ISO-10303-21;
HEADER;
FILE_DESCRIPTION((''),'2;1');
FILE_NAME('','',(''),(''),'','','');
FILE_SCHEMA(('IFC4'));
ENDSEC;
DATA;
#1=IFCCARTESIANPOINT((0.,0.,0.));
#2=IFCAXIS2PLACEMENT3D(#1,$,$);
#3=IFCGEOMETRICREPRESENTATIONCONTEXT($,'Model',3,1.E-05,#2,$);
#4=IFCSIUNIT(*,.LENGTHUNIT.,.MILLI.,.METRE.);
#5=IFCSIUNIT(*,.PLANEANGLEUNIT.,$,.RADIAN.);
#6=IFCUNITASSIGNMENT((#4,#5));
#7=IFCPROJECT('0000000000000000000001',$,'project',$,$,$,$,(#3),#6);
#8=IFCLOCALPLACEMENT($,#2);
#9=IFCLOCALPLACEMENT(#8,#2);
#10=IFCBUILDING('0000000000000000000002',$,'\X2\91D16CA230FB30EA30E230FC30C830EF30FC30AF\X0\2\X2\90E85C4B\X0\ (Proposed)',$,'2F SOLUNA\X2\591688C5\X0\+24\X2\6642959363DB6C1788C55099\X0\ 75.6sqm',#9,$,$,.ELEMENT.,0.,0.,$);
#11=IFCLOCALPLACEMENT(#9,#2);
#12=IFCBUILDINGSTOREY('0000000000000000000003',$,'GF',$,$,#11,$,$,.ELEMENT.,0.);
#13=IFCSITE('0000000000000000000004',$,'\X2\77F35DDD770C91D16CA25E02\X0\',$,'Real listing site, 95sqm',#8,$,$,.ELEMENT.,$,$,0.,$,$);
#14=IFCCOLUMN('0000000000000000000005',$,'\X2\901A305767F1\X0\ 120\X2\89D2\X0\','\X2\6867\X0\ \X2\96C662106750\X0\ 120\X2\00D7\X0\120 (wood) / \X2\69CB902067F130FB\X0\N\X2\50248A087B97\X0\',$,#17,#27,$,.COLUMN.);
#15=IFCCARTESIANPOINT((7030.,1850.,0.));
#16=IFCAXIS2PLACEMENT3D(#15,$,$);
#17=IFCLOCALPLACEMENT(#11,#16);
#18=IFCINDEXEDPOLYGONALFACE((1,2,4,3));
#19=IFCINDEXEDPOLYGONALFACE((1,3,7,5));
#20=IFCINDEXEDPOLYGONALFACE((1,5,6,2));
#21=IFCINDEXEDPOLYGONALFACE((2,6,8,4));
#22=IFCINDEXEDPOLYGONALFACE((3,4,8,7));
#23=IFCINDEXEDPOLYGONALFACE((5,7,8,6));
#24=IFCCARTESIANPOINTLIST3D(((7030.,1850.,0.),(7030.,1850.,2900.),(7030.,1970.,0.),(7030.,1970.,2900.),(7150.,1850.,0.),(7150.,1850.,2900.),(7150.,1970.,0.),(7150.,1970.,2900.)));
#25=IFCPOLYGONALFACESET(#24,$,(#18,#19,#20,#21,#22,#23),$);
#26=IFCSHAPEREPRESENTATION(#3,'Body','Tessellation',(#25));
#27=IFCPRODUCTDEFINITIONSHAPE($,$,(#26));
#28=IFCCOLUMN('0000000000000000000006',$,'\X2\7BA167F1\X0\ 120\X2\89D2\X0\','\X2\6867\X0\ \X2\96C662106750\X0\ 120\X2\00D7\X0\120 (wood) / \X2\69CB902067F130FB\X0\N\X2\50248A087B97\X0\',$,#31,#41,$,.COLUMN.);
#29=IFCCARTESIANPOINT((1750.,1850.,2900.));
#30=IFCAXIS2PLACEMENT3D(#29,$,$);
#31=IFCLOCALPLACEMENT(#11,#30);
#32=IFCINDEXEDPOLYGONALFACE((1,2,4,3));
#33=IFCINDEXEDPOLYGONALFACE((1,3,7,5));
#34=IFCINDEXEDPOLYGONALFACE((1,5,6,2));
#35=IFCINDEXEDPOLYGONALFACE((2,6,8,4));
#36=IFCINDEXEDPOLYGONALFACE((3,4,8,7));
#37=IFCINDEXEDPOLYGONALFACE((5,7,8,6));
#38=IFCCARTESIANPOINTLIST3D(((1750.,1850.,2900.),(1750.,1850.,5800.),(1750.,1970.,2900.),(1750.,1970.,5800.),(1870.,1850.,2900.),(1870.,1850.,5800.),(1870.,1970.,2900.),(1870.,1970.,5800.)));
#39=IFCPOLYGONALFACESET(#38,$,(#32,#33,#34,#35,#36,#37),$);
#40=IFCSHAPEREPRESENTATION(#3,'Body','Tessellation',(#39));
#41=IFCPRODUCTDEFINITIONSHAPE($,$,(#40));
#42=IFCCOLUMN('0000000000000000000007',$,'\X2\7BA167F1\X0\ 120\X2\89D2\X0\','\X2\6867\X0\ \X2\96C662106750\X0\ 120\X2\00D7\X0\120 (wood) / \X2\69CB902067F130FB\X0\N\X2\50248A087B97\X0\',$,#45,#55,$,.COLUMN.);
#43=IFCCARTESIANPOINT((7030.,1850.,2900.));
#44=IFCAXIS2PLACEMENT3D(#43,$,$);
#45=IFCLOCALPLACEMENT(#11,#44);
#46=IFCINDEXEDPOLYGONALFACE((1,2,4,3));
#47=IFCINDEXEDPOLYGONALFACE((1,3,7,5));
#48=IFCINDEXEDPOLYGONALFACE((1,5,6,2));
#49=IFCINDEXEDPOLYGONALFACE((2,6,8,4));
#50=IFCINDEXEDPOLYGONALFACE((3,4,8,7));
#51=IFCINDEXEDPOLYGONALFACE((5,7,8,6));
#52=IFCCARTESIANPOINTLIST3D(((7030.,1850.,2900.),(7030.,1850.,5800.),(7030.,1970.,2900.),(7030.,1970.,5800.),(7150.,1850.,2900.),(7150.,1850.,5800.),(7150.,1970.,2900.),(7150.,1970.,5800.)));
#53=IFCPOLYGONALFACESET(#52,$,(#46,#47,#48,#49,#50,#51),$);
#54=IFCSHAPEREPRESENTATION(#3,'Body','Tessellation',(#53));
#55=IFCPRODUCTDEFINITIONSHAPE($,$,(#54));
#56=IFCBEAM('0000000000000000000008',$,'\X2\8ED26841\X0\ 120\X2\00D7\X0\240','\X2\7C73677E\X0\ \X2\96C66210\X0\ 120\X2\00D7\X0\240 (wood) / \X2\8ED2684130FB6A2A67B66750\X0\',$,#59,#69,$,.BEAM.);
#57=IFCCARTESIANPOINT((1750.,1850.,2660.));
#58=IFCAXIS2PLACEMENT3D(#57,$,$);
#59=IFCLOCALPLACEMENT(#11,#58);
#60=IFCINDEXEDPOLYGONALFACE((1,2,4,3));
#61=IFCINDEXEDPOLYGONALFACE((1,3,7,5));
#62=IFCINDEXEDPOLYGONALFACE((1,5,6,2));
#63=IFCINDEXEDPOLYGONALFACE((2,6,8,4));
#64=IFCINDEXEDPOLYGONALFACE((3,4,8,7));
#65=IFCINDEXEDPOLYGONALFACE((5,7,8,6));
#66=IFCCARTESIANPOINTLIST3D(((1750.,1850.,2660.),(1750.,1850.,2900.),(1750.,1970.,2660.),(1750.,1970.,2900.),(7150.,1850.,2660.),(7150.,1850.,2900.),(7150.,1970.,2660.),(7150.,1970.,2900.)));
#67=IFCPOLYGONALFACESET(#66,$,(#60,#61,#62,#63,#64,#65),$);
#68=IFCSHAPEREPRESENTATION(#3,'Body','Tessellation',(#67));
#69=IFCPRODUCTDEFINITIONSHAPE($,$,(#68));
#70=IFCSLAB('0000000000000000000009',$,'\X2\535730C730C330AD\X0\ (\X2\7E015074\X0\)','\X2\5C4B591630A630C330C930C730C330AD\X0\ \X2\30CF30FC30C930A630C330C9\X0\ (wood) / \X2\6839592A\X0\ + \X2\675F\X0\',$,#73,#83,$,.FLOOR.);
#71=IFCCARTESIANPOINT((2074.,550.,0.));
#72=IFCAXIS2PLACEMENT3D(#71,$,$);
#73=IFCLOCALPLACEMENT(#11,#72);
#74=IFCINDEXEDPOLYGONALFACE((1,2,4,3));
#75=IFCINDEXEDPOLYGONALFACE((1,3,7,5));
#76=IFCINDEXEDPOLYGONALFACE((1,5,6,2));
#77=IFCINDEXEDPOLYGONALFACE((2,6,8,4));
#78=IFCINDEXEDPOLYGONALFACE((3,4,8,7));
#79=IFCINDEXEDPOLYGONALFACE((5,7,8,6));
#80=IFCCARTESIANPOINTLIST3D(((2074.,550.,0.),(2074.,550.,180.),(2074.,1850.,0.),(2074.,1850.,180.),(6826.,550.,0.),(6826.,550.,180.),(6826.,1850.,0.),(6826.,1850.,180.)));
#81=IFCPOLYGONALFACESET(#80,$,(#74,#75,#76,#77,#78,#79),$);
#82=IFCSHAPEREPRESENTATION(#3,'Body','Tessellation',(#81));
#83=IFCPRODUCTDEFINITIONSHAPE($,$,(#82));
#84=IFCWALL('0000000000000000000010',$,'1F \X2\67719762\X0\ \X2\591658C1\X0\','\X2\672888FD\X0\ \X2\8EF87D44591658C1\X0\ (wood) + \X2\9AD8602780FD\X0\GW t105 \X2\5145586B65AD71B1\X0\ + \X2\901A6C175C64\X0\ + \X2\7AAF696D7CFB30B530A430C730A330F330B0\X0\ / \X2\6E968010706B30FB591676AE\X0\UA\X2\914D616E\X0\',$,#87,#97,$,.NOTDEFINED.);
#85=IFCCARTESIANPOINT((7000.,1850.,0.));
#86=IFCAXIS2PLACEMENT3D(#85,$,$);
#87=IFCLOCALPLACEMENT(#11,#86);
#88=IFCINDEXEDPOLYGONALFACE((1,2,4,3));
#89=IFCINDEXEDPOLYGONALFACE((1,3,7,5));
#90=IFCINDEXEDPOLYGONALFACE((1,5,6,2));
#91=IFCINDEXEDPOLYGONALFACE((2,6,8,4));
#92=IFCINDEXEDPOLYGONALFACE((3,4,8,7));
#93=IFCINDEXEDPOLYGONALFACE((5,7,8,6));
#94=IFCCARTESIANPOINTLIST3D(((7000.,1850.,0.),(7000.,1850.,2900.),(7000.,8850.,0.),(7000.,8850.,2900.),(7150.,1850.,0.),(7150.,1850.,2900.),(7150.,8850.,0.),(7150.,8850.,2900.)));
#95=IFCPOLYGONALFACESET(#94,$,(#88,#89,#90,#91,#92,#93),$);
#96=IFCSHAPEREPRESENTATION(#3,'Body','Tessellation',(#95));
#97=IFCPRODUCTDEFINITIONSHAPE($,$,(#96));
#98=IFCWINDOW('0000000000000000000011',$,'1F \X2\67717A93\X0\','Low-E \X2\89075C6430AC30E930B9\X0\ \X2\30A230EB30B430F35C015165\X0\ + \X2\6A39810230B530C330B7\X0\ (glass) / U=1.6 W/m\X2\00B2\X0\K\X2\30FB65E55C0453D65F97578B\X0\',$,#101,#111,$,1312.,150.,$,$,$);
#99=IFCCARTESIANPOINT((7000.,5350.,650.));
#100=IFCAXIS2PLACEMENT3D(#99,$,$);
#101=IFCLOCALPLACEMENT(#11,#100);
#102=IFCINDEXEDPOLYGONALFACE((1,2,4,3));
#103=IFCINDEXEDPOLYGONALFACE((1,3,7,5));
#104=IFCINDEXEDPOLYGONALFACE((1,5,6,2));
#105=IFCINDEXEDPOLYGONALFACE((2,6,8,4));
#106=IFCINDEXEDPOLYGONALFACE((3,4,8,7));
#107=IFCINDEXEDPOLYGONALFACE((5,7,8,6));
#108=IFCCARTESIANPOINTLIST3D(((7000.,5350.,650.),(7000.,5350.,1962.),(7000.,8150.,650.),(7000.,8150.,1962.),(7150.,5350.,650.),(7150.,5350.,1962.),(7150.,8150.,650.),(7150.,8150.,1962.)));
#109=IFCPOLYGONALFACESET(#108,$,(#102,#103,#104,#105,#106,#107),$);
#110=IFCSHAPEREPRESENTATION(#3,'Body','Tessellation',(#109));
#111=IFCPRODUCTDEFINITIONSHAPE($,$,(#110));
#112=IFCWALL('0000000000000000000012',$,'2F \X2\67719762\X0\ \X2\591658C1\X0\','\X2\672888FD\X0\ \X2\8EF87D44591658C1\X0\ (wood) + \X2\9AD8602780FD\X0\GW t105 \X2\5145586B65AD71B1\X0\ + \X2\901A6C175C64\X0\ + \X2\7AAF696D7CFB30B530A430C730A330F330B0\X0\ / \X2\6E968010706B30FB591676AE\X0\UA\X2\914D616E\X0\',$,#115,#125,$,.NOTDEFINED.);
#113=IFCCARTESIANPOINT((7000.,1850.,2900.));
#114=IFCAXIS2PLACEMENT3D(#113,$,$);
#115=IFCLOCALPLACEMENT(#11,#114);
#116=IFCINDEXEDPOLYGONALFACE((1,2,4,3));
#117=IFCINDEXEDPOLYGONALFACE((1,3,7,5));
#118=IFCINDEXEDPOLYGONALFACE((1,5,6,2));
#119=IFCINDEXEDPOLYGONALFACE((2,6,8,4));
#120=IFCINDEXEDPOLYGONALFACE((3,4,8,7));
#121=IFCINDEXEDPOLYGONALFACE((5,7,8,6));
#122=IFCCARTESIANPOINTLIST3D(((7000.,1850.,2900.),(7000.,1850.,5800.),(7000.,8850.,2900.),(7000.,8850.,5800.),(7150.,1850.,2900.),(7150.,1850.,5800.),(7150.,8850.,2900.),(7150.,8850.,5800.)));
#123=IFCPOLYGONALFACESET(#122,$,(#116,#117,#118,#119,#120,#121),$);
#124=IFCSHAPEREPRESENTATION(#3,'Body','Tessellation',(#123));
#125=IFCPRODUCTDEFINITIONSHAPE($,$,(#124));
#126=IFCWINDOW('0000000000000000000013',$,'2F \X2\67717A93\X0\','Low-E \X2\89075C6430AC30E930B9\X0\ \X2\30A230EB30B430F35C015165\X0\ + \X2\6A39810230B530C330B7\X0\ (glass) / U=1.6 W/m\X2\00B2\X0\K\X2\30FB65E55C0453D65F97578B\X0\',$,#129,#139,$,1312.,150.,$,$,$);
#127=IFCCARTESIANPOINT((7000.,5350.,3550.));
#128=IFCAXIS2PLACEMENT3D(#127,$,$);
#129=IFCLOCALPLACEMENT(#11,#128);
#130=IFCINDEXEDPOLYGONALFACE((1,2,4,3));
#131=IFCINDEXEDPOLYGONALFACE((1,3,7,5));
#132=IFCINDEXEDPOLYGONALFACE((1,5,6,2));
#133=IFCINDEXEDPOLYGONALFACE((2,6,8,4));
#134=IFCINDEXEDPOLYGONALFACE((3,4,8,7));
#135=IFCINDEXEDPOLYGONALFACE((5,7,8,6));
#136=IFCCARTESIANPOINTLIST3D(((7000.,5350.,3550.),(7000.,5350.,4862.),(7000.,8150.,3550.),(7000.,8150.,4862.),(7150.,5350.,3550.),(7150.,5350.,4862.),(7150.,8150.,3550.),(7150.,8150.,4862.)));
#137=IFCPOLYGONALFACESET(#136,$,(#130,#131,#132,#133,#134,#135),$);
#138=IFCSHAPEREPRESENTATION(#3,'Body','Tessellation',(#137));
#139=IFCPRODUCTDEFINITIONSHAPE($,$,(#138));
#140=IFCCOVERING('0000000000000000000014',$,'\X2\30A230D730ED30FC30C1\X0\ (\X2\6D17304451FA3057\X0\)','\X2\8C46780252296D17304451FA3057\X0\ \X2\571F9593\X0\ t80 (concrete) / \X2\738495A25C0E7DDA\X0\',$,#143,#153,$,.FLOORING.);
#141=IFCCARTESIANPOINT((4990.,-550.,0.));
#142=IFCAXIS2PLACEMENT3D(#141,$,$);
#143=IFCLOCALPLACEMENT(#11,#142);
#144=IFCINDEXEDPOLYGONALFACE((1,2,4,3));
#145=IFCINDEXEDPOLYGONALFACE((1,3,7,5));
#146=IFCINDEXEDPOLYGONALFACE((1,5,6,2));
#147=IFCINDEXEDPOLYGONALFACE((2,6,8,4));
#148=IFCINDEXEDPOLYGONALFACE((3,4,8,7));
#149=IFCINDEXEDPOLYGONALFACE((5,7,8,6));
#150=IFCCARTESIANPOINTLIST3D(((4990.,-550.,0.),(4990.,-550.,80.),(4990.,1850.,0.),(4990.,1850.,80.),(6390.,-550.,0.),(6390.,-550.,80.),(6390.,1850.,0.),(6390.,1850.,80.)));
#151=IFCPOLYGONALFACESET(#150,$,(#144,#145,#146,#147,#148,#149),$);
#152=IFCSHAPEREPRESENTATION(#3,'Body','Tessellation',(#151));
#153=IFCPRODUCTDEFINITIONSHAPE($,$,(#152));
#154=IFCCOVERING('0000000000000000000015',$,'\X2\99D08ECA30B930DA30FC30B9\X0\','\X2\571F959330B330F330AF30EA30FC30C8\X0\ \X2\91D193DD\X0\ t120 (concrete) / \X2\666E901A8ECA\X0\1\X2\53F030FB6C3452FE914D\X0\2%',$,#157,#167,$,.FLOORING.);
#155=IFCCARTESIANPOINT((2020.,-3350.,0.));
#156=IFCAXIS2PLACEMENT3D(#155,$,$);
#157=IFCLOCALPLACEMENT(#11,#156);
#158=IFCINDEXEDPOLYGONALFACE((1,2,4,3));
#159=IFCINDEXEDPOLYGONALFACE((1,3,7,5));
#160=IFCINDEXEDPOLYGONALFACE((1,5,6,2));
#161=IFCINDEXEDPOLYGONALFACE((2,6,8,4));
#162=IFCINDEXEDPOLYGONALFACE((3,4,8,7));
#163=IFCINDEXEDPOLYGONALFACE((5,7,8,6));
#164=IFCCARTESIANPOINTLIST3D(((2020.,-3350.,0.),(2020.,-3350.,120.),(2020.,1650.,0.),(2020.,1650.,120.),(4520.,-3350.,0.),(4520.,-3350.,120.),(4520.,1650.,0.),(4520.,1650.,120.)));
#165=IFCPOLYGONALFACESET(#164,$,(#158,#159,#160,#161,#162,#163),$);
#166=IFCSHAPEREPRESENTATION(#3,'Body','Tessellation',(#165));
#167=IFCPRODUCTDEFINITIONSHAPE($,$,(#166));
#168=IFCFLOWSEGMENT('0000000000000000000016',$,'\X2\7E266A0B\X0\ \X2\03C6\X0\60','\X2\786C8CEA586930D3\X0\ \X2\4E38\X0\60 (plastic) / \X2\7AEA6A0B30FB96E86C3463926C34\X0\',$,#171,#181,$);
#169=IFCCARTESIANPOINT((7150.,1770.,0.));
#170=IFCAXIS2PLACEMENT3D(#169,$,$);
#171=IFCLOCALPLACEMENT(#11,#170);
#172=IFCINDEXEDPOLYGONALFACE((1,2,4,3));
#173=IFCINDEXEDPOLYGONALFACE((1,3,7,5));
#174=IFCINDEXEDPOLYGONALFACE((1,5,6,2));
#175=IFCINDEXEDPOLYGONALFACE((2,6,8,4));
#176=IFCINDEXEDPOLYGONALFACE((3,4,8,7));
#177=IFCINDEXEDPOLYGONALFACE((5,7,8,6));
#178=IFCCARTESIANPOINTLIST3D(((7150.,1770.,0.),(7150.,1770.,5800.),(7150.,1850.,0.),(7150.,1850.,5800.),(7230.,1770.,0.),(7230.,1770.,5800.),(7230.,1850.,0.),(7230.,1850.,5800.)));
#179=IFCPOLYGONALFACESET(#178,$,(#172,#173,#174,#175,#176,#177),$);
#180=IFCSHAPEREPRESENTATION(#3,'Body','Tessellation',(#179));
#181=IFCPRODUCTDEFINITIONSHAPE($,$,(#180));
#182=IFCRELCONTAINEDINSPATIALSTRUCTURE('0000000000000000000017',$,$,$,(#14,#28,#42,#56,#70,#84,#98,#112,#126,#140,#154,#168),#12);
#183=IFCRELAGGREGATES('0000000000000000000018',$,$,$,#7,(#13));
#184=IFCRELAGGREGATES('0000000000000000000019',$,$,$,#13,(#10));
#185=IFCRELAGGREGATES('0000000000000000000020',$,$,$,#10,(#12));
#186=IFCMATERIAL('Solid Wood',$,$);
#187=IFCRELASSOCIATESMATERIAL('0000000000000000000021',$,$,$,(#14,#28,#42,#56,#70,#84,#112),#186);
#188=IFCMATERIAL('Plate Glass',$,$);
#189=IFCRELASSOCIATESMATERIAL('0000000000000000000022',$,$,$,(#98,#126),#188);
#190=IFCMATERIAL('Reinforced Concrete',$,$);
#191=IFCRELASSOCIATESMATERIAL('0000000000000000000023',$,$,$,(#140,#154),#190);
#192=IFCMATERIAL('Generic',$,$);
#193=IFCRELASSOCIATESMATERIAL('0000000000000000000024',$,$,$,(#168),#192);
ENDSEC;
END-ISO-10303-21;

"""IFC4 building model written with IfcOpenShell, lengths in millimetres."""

from ifc_helpers import new_model, si_unit, frame, frame_2d, origin, place, context, project, spatial, rectangle, extrude, material, element, fill, save


model = new_model("IFC4")

# Units and contexts
model_context = context("Model", 3, precision=1e-05, world=origin())
ifc_project = project(units=[si_unit("LENGTHUNIT", "METRE", prefix="MILLI"), si_unit("PLANEANGLEUNIT", "RADIAN")], contexts=[model_context])

# Site, building, storey
site_placement = place(None, origin())
site = spatial("IfcSite", under=ifc_project, at=site_placement, Name="石川県金沢市", ObjectType="Real listing site, 95sqm", CompositionType="ELEMENT", RefElevation=0.0)
building_placement = place(site_placement, origin())
building = spatial("IfcBuilding", under=site, at=building_placement, Name="金沢・リモートワーク2部屋 (Proposed)", ObjectType="2F SOLUNA外装+24時間換気装備 75.6sqm", CompositionType="ELEMENT", ElevationOfRefHeight=0.0, ElevationOfTerrain=0.0)
storey_placement = place(building_placement, origin())
storey = spatial("IfcBuildingStorey", under=building, at=storey_placement, Name="GF", CompositionType="ELEMENT", Elevation=0.0)

# Columns
ifc_material_1 = material(Name="Solid Wood")
column_1_placement = place(storey_placement, frame((7030.0, 1850.0, 0.0)))
element("IfcColumn", 1, at=column_1_placement, inside=storey, material=ifc_material_1, Name="通し柱 120角", Description="桧 集成材 120×120 (wood) / 構造柱・N値計算", PredefinedType="COLUMN", context=model_context, shape_type="SweptSolid", body=[
    extrude(rectangle(XDim=120.0, YDim=120.0, at=frame_2d((60.0, 60.0))), frame((7030.0, 1850.0, 0.0)), (0.0, 0.0, 1.0), 2900.0),
])
column_2_placement = place(storey_placement, frame((1750.0, 1850.0, 2900.0)))
element("IfcColumn", 2, at=column_2_placement, inside=storey, material=ifc_material_1, Name="管柱 120角", Description="桧 集成材 120×120 (wood) / 構造柱・N値計算", PredefinedType="COLUMN", context=model_context, shape_type="SweptSolid", body=[
    extrude(rectangle(XDim=120.0, YDim=120.0, at=frame_2d((60.0, 60.0))), frame((1750.0, 1850.0, 2900.0)), (0.0, 0.0, 1.0), 2900.0),
])
column_3_placement = place(storey_placement, frame((7030.0, 1850.0, 2900.0)))
element("IfcColumn", 3, at=column_3_placement, inside=storey, material=ifc_material_1, Name="管柱 120角", Description="桧 集成材 120×120 (wood) / 構造柱・N値計算", PredefinedType="COLUMN", context=model_context, shape_type="SweptSolid", body=[
    extrude(rectangle(XDim=120.0, YDim=120.0, at=frame_2d((60.0, 60.0))), frame((7030.0, 1850.0, 2900.0)), (0.0, 0.0, 1.0), 2900.0),
])

# Beam
beam_1_placement = place(storey_placement, frame((1750.0, 1850.0, 2660.0)))
element("IfcBeam", 4, at=beam_1_placement, inside=storey, material=ifc_material_1, Name="軒桁 120×240", Description="米松 集成 120×240 (wood) / 軒桁・横架材", PredefinedType="BEAM", context=model_context, shape_type="SweptSolid", body=[
    extrude(rectangle(XDim=5400.0, YDim=120.0, at=frame_2d((2700.0, 60.0))), frame((1750.0, 1850.0, 2660.0)), (0.0, 0.0, 1.0), 240.0),
])

# Slab
slab_placement = place(storey_placement, frame((2074.0, 550.0, 0.0)))
element("IfcSlab", 5, at=slab_placement, inside=storey, material=ifc_material_1, Name="南デッキ (縁側)", Description="屋外ウッドデッキ ハードウッド (wood) / 根太 + 束", PredefinedType="FLOOR", context=model_context, shape_type="SweptSolid", body=[
    extrude(rectangle(XDim=4752.0, YDim=1300.0, at=frame_2d((2376.0, 650.0))), frame((2074.0, 550.0, 0.0)), (0.0, 0.0, 1.0), 180.0),
])

# Walls, openings, windows
wall_1_placement = place(storey_placement, frame((7000.0, 1850.0, 0.0)))
wall_1 = element("IfcWall", 6, at=wall_1_placement, inside=storey, material=ifc_material_1, Name="1F 東面 外壁", Description="木製 軸組外壁 (wood) + 高性能GW t105 充填断熱 + 通気層 + 窯業系サイディング / 準耐火・外皮UA配慮", PredefinedType="NOTDEFINED", context=model_context, shape_type="SweptSolid", body=[
    extrude(rectangle(XDim=150.0, YDim=7000.0, at=frame_2d((75.0, 3500.0))), frame((7000.0, 1850.0, 0.0)), (0.0, 0.0, 1.0), 2900.0),
])
opening_1_placement = place(storey_placement, frame((7000.0, 5350.0, 650.0)))
opening_1 = element("IfcOpeningElement", 7, at=opening_1_placement, cuts=wall_1, PredefinedType="NOTDEFINED", context=model_context, shape_type="SweptSolid", body=[
    extrude(rectangle(XDim=150.0, YDim=2800.0, at=frame_2d((75.0, 1400.0))), frame((7000.0, 5350.0, 650.0)), (0.0, 0.0, 1.0), 1312.0),
])
ifc_material_2 = material(Name="Plate Glass")
window_1_placement = place(storey_placement, frame((7000.0, 5350.0, 650.0)))
window_1 = element("IfcWindow", 8, at=window_1_placement, inside=storey, material=ifc_material_2, Name="1F 東窓", Description="Low-E 複層ガラス アルゴン封入 + 樹脂サッシ (glass) / U=1.6 W/m²K・日射取得型", OverallHeight=1312.0, OverallWidth=150.0, context=model_context, shape_type="SweptSolid", body=[
    extrude(rectangle(XDim=150.0, YDim=2800.0, at=frame_2d((75.0, 1400.0))), frame((7000.0, 5350.0, 650.0)), (0.0, 0.0, 1.0), 1312.0),
])
fill(opening_1, window_1)
wall_2_placement = place(storey_placement, frame((7000.0, 1850.0, 2900.0)))
wall_2 = element("IfcWall", 9, at=wall_2_placement, inside=storey, material=ifc_material_1, Name="2F 東面 外壁", Description="木製 軸組外壁 (wood) + 高性能GW t105 充填断熱 + 通気層 + 窯業系サイディング / 準耐火・外皮UA配慮", PredefinedType="NOTDEFINED", context=model_context, shape_type="SweptSolid", body=[
    extrude(rectangle(XDim=150.0, YDim=7000.0, at=frame_2d((75.0, 3500.0))), frame((7000.0, 1850.0, 2900.0)), (0.0, 0.0, 1.0), 2900.0),
])
opening_2_placement = place(storey_placement, frame((7000.0, 5350.0, 3550.0)))
opening_2 = element("IfcOpeningElement", 10, at=opening_2_placement, cuts=wall_2, PredefinedType="NOTDEFINED", context=model_context, shape_type="SweptSolid", body=[
    extrude(rectangle(XDim=150.0, YDim=2800.0, at=frame_2d((75.0, 1400.0))), frame((7000.0, 5350.0, 3550.0)), (0.0, 0.0, 1.0), 1312.0),
])
window_2_placement = place(storey_placement, frame((7000.0, 5350.0, 3550.0)))
window_2 = element("IfcWindow", 11, at=window_2_placement, inside=storey, material=ifc_material_2, Name="2F 東窓", Description="Low-E 複層ガラス アルゴン封入 + 樹脂サッシ (glass) / U=1.6 W/m²K・日射取得型", OverallHeight=1312.0, OverallWidth=150.0, context=model_context, shape_type="SweptSolid", body=[
    extrude(rectangle(XDim=150.0, YDim=2800.0, at=frame_2d((75.0, 1400.0))), frame((7000.0, 5350.0, 3550.0)), (0.0, 0.0, 1.0), 1312.0),
])
fill(opening_2, window_2)

# Coverings
ifc_material_3 = material(Name="Reinforced Concrete")
covering_1_placement = place(storey_placement, frame((4990.0, -550.0, 0.0)))
element("IfcCovering", 12, at=covering_1_placement, inside=storey, material=ifc_material_3, Name="アプローチ (洗い出し)", Description="豆砂利洗い出し 土間 t80 (concrete) / 玄関導線", PredefinedType="FLOORING", context=model_context, shape_type="SweptSolid", body=[
    extrude(rectangle(XDim=1400.0, YDim=2400.0, at=frame_2d((700.0, 1200.0))), frame((4990.0, -550.0, 0.0)), (0.0, 0.0, 1.0), 80.0),
])
covering_2_placement = place(storey_placement, frame((2020.0, -3350.0, 0.0)))
element("IfcCovering", 13, at=covering_2_placement, inside=storey, material=ifc_material_3, Name="駐車スペース", Description="土間コンクリート 金鏝 t120 (concrete) / 普通車1台・水勾配2%", PredefinedType="FLOORING", context=model_context, shape_type="SweptSolid", body=[
    extrude(rectangle(XDim=2500.0, YDim=5000.0, at=frame_2d((1250.0, 2500.0))), frame((2020.0, -3350.0, 0.0)), (0.0, 0.0, 1.0), 120.0),
])

# Flow segment
ifc_material_4 = material(Name="Generic")
flow_segment_placement = place(storey_placement, frame((7150.0, 1770.0, 0.0)))
element("IfcFlowSegment", 14, at=flow_segment_placement, inside=storey, material=ifc_material_4, Name="縦樋 φ60", Description="硬質塩ビ 丸60 (plastic) / 竪樋・雨水排水", context=model_context, shape_type="SweptSolid", body=[
    extrude(rectangle(XDim=80.0, YDim=80.0, at=frame_2d((40.0, 40.0))), frame((7150.0, 1770.0, 0.0)), (0.0, 0.0, 1.0), 5800.0),
])

save(model, "model.ifc")
